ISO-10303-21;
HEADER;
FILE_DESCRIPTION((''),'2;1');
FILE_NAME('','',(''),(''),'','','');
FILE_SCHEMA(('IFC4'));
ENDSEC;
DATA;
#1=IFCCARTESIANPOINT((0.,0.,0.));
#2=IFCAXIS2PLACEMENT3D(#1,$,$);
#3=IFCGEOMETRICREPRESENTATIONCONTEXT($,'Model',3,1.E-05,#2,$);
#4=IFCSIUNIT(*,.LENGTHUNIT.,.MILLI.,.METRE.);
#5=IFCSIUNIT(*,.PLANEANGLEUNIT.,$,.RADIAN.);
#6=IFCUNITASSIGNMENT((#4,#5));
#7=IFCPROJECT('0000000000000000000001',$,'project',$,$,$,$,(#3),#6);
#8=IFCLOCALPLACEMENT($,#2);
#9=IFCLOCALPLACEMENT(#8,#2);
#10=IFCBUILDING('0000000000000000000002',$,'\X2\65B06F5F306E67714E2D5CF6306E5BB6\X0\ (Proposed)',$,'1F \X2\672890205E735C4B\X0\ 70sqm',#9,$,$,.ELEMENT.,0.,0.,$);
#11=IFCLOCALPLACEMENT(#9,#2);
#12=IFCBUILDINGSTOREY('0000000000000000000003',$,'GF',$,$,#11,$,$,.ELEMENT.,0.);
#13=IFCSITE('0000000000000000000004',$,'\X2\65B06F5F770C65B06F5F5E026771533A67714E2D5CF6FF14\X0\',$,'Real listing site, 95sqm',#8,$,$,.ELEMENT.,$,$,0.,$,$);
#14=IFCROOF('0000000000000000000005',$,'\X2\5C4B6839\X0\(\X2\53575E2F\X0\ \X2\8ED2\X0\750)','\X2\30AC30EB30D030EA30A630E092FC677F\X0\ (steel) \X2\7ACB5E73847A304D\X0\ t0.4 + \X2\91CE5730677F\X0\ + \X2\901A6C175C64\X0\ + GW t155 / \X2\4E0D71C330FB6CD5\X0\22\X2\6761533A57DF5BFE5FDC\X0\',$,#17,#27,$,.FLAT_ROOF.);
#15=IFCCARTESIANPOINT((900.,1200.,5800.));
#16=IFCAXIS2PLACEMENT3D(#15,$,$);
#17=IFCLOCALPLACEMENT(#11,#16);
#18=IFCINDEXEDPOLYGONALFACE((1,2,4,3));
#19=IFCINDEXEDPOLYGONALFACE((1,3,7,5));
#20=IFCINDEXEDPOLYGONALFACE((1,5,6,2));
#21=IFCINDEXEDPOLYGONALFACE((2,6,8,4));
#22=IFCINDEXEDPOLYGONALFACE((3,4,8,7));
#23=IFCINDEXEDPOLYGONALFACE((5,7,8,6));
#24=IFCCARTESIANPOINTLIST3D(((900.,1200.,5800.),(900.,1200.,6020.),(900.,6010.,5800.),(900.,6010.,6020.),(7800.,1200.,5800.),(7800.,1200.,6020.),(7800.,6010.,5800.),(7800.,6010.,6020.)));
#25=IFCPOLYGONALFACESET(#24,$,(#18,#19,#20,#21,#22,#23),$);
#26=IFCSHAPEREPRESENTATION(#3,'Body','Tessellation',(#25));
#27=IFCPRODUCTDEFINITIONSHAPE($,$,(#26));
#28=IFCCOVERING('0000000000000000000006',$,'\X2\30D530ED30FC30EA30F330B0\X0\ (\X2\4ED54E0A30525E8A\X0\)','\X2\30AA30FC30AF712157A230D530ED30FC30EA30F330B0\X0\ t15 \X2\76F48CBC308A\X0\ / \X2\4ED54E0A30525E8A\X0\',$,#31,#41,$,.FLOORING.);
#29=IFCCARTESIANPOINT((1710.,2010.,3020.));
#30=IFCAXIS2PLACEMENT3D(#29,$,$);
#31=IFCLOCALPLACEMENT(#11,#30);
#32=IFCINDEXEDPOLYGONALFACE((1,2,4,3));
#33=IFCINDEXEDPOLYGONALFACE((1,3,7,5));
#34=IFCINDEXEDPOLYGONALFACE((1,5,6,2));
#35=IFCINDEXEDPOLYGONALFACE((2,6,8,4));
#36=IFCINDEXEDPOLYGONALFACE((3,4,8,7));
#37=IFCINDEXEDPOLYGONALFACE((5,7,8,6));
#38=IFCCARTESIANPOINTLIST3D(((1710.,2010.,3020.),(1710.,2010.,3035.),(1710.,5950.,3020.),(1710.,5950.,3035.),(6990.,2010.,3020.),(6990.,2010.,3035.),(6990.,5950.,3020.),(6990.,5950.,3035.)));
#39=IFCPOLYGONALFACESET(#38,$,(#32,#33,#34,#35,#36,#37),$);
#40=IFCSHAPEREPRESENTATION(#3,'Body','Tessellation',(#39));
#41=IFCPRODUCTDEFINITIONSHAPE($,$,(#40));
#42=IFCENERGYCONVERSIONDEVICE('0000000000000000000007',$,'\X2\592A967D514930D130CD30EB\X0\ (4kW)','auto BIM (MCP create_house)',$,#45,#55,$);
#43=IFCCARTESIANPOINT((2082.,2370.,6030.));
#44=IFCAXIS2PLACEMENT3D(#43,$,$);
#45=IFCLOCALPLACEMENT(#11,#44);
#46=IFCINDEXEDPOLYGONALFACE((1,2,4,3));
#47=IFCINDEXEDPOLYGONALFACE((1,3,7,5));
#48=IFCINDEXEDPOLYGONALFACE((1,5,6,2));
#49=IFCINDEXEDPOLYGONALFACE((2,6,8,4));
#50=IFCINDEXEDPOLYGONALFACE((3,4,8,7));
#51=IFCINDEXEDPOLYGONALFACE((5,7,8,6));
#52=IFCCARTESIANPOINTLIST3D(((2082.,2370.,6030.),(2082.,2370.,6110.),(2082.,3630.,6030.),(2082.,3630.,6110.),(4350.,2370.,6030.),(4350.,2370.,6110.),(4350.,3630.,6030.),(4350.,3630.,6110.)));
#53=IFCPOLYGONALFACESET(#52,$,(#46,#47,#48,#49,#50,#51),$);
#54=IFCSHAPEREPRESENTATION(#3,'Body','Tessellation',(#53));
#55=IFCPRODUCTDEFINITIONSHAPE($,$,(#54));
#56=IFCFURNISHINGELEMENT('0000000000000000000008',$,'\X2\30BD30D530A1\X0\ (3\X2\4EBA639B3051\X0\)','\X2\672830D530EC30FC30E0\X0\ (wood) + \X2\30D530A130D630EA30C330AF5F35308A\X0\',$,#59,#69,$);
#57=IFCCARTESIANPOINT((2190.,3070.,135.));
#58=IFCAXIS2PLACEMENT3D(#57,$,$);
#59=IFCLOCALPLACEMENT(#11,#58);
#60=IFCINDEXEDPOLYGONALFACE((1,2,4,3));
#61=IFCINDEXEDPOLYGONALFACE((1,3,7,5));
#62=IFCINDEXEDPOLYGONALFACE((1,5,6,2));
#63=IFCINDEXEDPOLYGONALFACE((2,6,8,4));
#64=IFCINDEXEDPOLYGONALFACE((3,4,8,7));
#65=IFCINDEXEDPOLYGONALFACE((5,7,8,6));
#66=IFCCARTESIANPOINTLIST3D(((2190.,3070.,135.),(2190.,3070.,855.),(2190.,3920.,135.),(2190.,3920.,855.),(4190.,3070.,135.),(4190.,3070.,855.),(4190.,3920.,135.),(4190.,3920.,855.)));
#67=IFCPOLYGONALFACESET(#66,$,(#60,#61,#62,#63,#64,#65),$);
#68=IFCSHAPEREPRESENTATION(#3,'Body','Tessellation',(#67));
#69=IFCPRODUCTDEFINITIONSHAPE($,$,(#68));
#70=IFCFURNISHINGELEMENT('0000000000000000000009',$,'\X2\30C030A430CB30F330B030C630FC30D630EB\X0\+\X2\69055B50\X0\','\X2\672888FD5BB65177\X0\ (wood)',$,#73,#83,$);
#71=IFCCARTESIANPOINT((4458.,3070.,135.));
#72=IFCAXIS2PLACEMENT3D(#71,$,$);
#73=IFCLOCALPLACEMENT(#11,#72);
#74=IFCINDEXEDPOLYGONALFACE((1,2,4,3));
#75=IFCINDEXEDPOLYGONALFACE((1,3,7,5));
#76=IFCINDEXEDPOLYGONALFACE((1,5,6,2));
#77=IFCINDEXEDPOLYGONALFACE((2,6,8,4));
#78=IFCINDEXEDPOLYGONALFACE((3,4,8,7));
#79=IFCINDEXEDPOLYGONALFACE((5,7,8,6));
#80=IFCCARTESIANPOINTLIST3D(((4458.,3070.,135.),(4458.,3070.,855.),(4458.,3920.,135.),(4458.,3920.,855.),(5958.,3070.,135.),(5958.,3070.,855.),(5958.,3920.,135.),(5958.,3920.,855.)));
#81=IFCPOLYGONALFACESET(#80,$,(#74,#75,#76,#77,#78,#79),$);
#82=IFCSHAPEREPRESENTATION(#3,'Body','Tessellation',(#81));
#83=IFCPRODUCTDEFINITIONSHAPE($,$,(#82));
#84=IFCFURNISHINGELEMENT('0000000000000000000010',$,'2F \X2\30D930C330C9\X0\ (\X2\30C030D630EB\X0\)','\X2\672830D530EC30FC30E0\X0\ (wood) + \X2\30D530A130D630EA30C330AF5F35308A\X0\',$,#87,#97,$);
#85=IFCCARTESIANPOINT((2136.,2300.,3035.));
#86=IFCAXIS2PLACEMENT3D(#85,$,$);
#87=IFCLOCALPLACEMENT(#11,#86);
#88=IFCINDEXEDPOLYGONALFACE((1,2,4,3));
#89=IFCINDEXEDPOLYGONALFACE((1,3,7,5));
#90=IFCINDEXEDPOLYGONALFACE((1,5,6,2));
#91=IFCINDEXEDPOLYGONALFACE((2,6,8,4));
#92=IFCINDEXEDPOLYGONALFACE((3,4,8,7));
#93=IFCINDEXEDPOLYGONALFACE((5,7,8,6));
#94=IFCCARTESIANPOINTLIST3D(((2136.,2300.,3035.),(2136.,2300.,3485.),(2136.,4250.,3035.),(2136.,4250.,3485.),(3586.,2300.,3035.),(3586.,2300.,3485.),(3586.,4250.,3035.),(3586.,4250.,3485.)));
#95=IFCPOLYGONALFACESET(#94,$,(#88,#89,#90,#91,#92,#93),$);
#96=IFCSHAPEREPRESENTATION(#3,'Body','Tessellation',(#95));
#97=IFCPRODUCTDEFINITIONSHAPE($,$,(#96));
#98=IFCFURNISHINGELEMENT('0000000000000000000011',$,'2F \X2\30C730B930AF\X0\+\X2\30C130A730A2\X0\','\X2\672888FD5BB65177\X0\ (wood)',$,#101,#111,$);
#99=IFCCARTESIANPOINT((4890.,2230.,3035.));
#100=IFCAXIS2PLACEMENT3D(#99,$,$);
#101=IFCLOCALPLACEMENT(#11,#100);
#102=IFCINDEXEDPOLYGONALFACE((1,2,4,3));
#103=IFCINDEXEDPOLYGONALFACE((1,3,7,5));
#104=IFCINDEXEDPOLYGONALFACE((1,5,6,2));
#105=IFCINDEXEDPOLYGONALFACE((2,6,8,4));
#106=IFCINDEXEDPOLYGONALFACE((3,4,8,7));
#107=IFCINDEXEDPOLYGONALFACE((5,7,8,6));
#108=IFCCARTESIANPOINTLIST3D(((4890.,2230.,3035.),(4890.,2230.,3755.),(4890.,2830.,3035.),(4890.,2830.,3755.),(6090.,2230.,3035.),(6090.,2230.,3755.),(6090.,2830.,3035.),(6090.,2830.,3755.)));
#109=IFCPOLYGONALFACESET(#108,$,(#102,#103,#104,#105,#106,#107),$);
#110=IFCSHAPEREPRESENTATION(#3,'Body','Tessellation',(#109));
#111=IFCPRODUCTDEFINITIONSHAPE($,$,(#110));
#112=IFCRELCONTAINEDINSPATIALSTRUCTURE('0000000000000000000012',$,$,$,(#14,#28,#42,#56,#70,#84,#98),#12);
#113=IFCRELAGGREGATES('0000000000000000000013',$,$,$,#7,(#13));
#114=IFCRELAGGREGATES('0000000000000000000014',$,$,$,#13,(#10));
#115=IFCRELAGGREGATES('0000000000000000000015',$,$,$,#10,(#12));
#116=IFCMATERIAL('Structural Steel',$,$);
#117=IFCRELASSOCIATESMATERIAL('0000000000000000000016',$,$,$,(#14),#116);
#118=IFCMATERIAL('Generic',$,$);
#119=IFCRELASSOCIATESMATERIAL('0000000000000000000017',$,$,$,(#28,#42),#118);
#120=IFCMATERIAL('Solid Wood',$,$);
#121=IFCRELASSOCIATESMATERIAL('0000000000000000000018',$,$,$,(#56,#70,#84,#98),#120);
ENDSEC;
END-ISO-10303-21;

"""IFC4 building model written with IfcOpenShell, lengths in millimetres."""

from ifc_helpers import new_model, si_unit, frame, frame_2d, origin, place, context, project, spatial, rectangle, extrude, material, element, save


model = new_model("IFC4")

# Units and contexts
model_context = context("Model", 3, precision=1e-05, world=origin())
ifc_project = project(units=[si_unit("LENGTHUNIT", "METRE", prefix="MILLI"), si_unit("PLANEANGLEUNIT", "RADIAN")], contexts=[model_context])

# Site, building, storey
site_placement = place(None, origin())
site = spatial("IfcSite", under=ifc_project, at=site_placement, Name="新潟県新潟市東区東中島４", ObjectType="Real listing site, 95sqm", CompositionType="ELEMENT", RefElevation=0.0)
building_placement = place(site_placement, origin())
building = spatial("IfcBuilding", under=site, at=building_placement, Name="新潟の東中島の家 (Proposed)", ObjectType="1F 木造平屋 70sqm", CompositionType="ELEMENT", ElevationOfRefHeight=0.0, ElevationOfTerrain=0.0)
storey_placement = place(building_placement, origin())
storey = spatial("IfcBuildingStorey", under=building, at=storey_placement, Name="GF", CompositionType="ELEMENT", Elevation=0.0)

# Shared definitions
ifc_material_1 = material(Name="Solid Wood")

# Shared definitions
ifc_material_2 = material(Name="Generic")

# Roof
ifc_material_3 = material(Name="Structural Steel")
for number, where, name in (
    (1, (900.0, 1200.0, 5800.0), "屋根(南帯 軒750)"),
):
    element("IfcRoof", number, at=place(storey_placement, frame(where)), inside=storey, material=ifc_material_3, Name=name, Description="ガルバリウム鋼板 (steel) 立平葺き t0.4 + 野地板 + 通気層 + GW t155 / 不燃・法22条区域対応", PredefinedType="FLAT_ROOF", context=model_context, shape_type="SweptSolid", body=[
        extrude(rectangle(XDim=6900.0, YDim=4810.0, at=frame_2d((3450.0, 2405.0))), frame((900.0, 1200.0, 5800.0)), (0.0, 0.0, 1.0), 220.0),
    ])

# Covering
covering_placement = place(storey_placement, frame((1710.0, 2010.0, 3020.0)))
element("IfcCovering", 2, at=covering_placement, inside=storey, material=ifc_material_2, Name="フローリング (仕上げ床)", Description="オーク無垢フローリング t15 直貼り / 仕上げ床", PredefinedType="FLOORING", context=model_context, shape_type="SweptSolid", body=[
    extrude(rectangle(XDim=5280.0, YDim=3940.0, at=frame_2d((2640.0, 1970.0))), frame((1710.0, 2010.0, 3020.0)), (0.0, 0.0, 1.0), 15.0),
])

# Energy conversion device
energy_conversion_device_placement = place(storey_placement, frame((2082.0, 2370.0, 6030.0)))
element("IfcEnergyConversionDevice", 3, at=energy_conversion_device_placement, inside=storey, material=ifc_material_2, Name="太陽光パネル (4kW)", Description="auto BIM (MCP create_house)", context=model_context, shape_type="SweptSolid", body=[
    extrude(rectangle(XDim=2268.0, YDim=1260.0, at=frame_2d((1134.0, 630.0))), frame((2082.0, 2370.0, 6030.0)), (0.0, 0.0, 1.0), 80.0),
])

# Furnishing elements
furnishing_1_placement = place(storey_placement, frame((2190.0, 3070.0, 135.0)))
element("IfcFurnishingElement", 4, at=furnishing_1_placement, inside=storey, material=ifc_material_1, Name="ソファ (3人掛け)", Description="木フレーム (wood) + ファブリック張り", context=model_context, shape_type="SweptSolid", body=[
    extrude(rectangle(XDim=2000.0, YDim=850.0, at=frame_2d((1000.0, 425.0))), frame((2190.0, 3070.0, 135.0)), (0.0, 0.0, 1.0), 720.0),
])
furnishing_2_placement = place(storey_placement, frame((4458.0, 3070.0, 135.0)))
element("IfcFurnishingElement", 5, at=furnishing_2_placement, inside=storey, material=ifc_material_1, Name="ダイニングテーブル+椅子", Description="木製家具 (wood)", context=model_context, shape_type="SweptSolid", body=[
    extrude(rectangle(XDim=1500.0, YDim=850.0, at=frame_2d((750.0, 425.0))), frame((4458.0, 3070.0, 135.0)), (0.0, 0.0, 1.0), 720.0),
])
furnishing_3_placement = place(storey_placement, frame((2136.0, 2300.0, 3035.0)))
element("IfcFurnishingElement", 6, at=furnishing_3_placement, inside=storey, material=ifc_material_1, Name="2F ベッド (ダブル)", Description="木フレーム (wood) + ファブリック張り", context=model_context, shape_type="SweptSolid", body=[
    extrude(rectangle(XDim=1450.0, YDim=1950.0, at=frame_2d((725.0, 975.0))), frame((2136.0, 2300.0, 3035.0)), (0.0, 0.0, 1.0), 450.0),
])
furnishing_4_placement = place(storey_placement, frame((4890.0, 2230.0, 3035.0)))
element("IfcFurnishingElement", 7, at=furnishing_4_placement, inside=storey, material=ifc_material_1, Name="2F デスク+チェア", Description="木製家具 (wood)", context=model_context, shape_type="SweptSolid", body=[
    extrude(rectangle(XDim=1200.0, YDim=600.0, at=frame_2d((600.0, 300.0))), frame((4890.0, 2230.0, 3035.0)), (0.0, 0.0, 1.0), 720.0),
])

save(model, "model.ifc")
